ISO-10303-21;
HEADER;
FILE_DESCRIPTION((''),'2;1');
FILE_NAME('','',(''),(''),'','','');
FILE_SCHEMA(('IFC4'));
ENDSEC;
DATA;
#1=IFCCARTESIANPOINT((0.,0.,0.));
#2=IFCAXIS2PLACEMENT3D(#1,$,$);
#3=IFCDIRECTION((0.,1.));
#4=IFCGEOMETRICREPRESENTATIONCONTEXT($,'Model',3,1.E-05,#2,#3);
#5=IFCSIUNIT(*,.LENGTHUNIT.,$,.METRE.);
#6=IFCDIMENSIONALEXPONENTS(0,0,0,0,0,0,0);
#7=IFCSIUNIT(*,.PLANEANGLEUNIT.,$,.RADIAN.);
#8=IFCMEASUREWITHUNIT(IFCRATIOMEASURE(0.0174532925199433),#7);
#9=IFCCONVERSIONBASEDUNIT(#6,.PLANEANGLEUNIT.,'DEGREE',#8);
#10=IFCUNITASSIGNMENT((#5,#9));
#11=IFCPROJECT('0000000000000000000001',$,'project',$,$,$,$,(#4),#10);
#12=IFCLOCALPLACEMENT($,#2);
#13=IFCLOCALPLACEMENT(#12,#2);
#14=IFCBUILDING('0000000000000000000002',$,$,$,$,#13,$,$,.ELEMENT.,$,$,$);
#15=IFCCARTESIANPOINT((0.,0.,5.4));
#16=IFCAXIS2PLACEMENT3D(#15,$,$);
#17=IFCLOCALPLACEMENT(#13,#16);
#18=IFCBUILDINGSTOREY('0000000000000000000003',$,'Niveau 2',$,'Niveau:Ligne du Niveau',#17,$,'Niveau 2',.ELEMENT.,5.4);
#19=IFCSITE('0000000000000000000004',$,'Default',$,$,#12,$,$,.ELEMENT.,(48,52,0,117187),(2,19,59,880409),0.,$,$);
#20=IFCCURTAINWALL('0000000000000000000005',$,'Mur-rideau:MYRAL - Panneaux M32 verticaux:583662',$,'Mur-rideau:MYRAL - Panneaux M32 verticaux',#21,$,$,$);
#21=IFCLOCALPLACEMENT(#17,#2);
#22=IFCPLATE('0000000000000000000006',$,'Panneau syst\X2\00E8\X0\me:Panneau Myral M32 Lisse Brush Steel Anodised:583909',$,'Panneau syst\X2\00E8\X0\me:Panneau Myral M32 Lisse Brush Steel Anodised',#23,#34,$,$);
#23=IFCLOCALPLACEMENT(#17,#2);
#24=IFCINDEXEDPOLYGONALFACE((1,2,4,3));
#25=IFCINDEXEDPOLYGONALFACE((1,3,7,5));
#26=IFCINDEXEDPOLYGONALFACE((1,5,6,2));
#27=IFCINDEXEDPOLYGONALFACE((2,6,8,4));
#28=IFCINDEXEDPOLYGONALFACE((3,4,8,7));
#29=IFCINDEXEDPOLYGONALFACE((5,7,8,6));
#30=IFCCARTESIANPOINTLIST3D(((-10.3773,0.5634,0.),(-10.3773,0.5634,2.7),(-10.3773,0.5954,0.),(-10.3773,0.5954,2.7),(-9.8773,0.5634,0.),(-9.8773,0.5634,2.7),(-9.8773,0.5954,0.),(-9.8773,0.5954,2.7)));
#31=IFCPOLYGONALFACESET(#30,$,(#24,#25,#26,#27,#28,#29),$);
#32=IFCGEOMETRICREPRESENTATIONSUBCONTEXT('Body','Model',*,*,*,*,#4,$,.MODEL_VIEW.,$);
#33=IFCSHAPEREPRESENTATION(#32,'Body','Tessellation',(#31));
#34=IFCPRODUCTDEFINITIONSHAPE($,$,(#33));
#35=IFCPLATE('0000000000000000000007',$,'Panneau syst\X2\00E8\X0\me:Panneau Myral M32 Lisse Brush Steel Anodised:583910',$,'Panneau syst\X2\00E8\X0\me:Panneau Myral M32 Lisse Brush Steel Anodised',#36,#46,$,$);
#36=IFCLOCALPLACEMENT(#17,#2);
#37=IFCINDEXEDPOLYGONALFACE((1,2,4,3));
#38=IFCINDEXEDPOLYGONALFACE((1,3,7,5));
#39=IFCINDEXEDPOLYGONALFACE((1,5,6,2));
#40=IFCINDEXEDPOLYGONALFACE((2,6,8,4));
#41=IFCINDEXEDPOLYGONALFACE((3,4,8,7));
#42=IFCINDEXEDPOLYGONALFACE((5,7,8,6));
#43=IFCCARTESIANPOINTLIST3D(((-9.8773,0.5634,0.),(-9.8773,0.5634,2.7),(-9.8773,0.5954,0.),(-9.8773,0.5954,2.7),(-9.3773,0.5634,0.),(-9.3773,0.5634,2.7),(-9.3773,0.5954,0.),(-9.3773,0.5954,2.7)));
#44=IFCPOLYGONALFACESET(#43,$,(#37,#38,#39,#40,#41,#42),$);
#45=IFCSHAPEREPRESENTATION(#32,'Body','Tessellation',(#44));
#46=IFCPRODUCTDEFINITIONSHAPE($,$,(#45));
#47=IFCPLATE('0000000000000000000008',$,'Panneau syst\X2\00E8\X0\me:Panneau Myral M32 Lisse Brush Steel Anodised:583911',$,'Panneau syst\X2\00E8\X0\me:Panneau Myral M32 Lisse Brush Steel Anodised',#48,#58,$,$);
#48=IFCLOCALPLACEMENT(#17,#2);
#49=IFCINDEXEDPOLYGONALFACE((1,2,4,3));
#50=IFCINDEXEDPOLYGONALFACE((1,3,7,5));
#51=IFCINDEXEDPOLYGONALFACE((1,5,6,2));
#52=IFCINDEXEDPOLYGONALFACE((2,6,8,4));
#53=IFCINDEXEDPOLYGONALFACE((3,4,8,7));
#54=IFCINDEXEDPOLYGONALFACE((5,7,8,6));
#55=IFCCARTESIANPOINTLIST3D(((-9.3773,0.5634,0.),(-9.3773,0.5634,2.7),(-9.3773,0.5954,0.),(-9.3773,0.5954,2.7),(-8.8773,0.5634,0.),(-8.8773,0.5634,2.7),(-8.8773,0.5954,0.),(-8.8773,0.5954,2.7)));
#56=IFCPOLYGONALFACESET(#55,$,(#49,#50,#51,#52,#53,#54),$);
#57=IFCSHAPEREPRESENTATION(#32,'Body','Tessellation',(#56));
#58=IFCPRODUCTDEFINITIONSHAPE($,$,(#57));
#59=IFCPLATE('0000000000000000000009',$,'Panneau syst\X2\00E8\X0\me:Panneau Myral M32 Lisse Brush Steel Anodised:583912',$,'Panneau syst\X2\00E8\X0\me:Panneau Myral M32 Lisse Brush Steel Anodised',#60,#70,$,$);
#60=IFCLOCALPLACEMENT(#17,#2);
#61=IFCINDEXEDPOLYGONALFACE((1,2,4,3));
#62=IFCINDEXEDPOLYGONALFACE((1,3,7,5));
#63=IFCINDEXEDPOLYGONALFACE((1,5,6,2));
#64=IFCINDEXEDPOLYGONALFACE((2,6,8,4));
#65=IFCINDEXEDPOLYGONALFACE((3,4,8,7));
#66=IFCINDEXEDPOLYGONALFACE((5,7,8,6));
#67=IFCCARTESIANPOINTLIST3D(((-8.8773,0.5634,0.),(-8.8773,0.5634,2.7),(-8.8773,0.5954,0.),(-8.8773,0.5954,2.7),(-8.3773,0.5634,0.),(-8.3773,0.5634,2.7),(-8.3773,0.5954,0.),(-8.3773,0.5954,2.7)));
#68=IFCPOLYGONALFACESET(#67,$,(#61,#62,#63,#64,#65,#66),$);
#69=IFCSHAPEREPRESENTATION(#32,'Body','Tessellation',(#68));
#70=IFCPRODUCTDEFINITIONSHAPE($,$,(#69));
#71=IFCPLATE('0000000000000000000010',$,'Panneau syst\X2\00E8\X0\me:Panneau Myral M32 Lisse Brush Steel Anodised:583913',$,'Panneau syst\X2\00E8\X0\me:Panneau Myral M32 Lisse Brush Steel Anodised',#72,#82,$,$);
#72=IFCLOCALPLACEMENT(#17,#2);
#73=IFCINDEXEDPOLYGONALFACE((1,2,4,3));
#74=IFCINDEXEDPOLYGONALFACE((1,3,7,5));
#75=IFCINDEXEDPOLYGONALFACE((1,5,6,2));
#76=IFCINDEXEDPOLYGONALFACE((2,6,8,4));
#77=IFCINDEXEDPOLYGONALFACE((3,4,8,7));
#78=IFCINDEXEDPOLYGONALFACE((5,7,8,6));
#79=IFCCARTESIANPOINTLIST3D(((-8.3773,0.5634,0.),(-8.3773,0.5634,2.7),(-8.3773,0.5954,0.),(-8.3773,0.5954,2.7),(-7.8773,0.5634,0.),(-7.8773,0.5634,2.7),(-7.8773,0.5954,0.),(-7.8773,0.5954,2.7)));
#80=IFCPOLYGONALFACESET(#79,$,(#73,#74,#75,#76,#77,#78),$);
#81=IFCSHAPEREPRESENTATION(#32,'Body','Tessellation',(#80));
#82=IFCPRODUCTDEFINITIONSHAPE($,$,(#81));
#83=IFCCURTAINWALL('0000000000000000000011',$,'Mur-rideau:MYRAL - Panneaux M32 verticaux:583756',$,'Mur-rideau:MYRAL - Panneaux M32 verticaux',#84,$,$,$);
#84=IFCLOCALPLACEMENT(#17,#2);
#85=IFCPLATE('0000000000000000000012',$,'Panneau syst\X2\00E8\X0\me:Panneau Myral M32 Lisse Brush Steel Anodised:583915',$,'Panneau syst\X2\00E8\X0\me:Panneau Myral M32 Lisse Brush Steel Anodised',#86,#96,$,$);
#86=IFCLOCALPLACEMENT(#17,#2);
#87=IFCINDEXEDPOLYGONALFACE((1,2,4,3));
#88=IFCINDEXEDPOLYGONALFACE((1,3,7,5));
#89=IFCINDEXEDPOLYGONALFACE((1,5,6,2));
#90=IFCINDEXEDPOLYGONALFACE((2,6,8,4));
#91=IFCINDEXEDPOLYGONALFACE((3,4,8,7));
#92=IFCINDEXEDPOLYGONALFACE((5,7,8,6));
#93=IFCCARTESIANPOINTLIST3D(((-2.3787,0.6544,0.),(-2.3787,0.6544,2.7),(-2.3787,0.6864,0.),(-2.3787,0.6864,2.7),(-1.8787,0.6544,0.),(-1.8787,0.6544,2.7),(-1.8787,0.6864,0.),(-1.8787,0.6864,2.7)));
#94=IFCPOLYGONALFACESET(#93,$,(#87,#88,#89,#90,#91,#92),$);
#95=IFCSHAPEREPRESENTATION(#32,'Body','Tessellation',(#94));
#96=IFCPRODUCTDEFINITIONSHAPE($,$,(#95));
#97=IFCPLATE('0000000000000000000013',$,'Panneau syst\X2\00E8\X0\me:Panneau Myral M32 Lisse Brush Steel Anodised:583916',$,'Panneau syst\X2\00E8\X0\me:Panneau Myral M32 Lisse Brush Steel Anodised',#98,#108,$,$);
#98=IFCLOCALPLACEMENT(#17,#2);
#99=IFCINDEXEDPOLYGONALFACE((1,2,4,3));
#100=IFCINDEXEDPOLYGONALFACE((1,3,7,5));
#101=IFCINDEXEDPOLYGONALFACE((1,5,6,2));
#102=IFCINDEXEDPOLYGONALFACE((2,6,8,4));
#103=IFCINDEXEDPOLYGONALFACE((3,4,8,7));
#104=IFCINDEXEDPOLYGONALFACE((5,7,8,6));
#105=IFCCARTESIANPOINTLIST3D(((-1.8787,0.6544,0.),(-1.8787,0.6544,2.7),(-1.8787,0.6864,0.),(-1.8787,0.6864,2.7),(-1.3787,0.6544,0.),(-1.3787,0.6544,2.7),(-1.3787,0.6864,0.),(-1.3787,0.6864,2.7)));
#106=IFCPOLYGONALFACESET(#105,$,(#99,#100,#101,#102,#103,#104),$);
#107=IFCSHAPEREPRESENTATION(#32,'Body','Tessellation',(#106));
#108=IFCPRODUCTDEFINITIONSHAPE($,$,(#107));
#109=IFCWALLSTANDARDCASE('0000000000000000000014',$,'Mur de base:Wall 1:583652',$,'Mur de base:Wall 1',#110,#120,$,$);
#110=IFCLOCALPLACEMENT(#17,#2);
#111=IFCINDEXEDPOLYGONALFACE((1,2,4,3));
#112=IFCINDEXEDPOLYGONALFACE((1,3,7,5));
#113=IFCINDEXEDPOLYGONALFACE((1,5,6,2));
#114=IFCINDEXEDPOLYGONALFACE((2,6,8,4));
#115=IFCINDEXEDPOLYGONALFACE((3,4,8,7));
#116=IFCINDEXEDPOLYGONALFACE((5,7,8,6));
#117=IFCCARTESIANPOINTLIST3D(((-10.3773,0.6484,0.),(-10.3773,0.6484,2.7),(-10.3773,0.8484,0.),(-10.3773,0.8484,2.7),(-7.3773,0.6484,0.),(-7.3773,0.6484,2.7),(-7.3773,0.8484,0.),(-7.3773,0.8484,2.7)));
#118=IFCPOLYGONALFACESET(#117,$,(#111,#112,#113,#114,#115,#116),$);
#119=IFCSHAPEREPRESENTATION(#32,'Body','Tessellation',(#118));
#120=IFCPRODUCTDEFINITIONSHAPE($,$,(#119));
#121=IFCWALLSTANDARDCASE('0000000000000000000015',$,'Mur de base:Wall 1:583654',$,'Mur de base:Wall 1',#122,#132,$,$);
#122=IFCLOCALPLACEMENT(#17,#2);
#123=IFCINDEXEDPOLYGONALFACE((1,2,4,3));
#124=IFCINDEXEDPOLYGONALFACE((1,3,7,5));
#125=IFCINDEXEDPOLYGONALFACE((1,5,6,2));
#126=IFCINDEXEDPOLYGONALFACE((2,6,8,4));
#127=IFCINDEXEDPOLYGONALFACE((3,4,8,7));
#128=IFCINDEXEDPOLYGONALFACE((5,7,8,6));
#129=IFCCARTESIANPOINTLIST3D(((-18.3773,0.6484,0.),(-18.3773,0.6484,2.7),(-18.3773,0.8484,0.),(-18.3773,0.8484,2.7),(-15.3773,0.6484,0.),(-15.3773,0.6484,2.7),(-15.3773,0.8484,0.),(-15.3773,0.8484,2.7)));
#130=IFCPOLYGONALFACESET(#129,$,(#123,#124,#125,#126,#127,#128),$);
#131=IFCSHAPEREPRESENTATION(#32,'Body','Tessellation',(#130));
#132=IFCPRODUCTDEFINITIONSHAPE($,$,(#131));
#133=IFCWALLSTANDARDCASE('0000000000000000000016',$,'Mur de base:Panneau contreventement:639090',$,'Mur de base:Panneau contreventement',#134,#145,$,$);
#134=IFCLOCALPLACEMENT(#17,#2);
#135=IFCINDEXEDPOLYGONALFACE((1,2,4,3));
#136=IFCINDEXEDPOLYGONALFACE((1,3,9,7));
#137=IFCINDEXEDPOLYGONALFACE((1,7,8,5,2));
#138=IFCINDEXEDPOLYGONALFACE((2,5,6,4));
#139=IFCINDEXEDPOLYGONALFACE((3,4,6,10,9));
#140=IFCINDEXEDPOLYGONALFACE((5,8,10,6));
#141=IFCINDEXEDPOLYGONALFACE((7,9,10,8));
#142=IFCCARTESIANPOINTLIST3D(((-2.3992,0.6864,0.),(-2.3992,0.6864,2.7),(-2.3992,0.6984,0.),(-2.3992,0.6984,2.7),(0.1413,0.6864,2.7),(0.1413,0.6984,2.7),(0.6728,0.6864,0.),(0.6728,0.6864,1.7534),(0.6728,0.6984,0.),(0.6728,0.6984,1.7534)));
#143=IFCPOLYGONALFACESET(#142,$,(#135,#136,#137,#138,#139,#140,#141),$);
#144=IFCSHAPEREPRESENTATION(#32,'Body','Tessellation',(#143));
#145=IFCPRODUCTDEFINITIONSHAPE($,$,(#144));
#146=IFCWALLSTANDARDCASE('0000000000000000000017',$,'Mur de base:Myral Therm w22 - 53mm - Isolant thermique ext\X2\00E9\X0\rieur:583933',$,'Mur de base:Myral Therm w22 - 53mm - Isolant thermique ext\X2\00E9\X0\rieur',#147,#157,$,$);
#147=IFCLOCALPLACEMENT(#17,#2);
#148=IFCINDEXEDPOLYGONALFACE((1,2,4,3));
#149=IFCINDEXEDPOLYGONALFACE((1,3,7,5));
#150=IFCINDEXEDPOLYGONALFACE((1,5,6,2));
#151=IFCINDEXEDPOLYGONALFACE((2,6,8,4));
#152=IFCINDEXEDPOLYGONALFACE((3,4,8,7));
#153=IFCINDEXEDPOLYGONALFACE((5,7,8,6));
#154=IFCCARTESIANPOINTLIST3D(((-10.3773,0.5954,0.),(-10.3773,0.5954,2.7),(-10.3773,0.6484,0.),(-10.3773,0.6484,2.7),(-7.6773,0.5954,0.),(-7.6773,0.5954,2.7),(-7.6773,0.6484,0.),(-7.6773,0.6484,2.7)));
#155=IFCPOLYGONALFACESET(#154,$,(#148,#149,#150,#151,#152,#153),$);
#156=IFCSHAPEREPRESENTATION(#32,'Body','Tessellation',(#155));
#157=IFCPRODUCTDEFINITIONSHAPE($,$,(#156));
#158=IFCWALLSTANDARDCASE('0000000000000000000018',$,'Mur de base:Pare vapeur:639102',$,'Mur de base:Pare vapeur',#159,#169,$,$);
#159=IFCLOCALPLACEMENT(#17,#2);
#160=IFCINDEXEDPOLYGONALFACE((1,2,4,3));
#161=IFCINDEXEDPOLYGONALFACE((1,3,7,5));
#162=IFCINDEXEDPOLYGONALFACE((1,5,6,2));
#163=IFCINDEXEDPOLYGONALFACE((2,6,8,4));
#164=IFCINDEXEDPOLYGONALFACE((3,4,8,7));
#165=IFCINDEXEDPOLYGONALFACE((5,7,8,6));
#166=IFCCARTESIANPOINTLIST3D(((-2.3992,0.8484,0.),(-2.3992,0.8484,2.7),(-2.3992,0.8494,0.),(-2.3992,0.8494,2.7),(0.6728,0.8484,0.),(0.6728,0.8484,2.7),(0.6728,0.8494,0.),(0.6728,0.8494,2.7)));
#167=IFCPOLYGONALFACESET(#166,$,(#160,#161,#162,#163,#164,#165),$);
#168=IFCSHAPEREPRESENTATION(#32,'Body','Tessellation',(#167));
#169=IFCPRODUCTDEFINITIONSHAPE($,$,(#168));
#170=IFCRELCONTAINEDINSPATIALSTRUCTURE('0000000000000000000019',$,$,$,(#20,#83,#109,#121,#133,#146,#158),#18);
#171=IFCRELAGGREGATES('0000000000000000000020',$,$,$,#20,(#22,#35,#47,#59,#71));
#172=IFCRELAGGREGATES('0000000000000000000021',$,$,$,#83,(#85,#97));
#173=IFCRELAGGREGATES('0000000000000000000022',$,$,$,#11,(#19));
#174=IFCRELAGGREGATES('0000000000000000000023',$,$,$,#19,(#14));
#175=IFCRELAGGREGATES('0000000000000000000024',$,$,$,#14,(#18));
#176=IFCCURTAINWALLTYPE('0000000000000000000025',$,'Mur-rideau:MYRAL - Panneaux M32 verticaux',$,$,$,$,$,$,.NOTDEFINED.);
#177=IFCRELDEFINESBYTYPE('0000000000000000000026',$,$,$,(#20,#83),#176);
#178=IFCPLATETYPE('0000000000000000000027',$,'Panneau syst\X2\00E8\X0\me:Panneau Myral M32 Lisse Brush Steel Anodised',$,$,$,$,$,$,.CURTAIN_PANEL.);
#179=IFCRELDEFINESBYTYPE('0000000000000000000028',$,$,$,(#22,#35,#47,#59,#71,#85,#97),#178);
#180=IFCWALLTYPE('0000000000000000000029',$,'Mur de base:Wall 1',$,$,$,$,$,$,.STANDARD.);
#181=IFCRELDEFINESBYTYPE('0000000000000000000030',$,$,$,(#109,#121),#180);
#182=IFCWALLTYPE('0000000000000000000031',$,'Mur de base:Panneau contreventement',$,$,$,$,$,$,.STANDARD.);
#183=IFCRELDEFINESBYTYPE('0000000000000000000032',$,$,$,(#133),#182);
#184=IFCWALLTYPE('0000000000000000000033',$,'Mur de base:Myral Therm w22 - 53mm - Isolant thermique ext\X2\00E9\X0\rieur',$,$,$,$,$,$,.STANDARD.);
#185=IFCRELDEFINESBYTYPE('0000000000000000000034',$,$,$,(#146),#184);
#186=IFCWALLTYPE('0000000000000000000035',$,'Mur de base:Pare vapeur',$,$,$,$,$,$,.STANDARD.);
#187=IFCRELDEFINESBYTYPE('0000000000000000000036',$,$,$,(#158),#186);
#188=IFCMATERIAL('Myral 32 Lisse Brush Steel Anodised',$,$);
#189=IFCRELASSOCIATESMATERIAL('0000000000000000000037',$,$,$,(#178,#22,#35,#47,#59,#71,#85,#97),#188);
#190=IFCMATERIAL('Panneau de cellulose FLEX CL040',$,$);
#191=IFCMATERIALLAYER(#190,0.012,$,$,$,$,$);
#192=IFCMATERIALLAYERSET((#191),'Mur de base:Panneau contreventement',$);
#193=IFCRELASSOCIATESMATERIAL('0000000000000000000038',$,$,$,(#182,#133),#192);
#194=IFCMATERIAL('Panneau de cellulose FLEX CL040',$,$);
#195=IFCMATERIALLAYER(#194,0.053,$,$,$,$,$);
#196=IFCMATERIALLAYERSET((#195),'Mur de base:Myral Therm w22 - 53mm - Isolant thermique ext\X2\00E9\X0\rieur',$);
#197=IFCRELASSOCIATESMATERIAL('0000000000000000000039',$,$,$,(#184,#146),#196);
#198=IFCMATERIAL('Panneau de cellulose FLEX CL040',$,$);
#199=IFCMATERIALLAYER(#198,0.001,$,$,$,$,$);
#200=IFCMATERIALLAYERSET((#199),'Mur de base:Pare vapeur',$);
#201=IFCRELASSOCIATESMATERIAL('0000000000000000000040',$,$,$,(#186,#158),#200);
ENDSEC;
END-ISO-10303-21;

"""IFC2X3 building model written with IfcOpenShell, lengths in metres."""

from ifc_helpers import new_model, entity, si_unit, converted_unit, direction, frame, frame_2d, origin, origin_2d_with_axis, place, context, subcontext, project, spatial, rectangle, extrude, clip, halfspace, source, transform, mapped, material, layer, layer_set, layer_usage, type_object, type_shapes, element, aggregate, save


model = new_model("IFC2X3")

# Units and contexts
model_context = context("Model", 3, precision=1e-05, world=origin(), true_north=direction((0.0, 1.0)))
body_context = subcontext(model_context, "Body", "Model", "MODEL_VIEW")
ifc_project = project(units=[si_unit("LENGTHUNIT", "METRE"), converted_unit("PLANEANGLEUNIT", "DEGREE", entity("IfcRatioMeasure", 0.0174532925199433), si_unit("PLANEANGLEUNIT", "RADIAN"), dimensions=[0, 0, 0, 0, 0, 0, 0])], contexts=[model_context])

# Site, building, storey
site_placement = place(None, origin())
site = spatial("IfcSite", under=ifc_project, at=site_placement, Name="Default", CompositionType="ELEMENT", RefLatitude=(48, 52, 0, 117187), RefLongitude=(2, 19, 59, 880409), RefElevation=0.0)
building_placement = place(site_placement, origin())
building = spatial("IfcBuilding", under=site, at=building_placement, CompositionType="ELEMENT")
storey_placement = place(building_placement, frame((0.0, 0.0, 5.4)))
storey = spatial("IfcBuildingStorey", under=building, at=storey_placement, Name="Niveau 2", ObjectType="Niveau:Ligne du Niveau", LongName="Niveau 2", CompositionType="ELEMENT", Elevation=5.4)

# Shared definitions
ifc_material_1 = material(Name="Panneau de cellulose FLEX CL040")

# Curtain walls, plates
curtain_wall_type_1 = type_object("IfcCurtainWallType", Name="Mur-rideau:MYRAL - Panneaux M32 verticaux", PredefinedType="NOTDEFINED")
ifc_material_2 = material(Name="Myral 32 Lisse Brush Steel Anodised")
plate_type = type_object("IfcPlateType", Name="Panneau système:Panneau Myral M32 Lisse Brush Steel Anodised", PredefinedType="CURTAIN_PANEL", material=ifc_material_2)
shared_shape_1 = source(origin(), body_context, "Body", "SweptSolid", [
    extrude(rectangle(XDim=0.032, YDim=0.5, at=origin_2d_with_axis()), frame((0.0, -0.016, 0.0), z_axis=(0.0, 0.0, 1.0), x_axis=(0.0, 1.0, 0.0)), (0.0, 0.0, 1.0), 2.7),
])
type_shapes(plate_type, [shared_shape_1])
curtain_wall_1_placement = place(storey_placement, frame((0.0, 0.0, -5.4)))
curtain_wall_1 = element("IfcCurtainWall", 1, at=curtain_wall_1_placement, inside=storey, type_object=curtain_wall_type_1, Name="Mur-rideau:MYRAL - Panneaux M32 verticaux:583662", ObjectType="Mur-rideau:MYRAL - Panneaux M32 verticaux")
plate_1_placement = place(curtain_wall_1_placement, frame((-10.1273, 0.5954, 5.4)))
plate_1 = element("IfcPlate", 2, at=plate_1_placement, type_object=plate_type, material=ifc_material_2, Name="Panneau système:Panneau Myral M32 Lisse Brush Steel Anodised:583909", ObjectType="Panneau système:Panneau Myral M32 Lisse Brush Steel Anodised", context=body_context, shape_type="MappedRepresentation", body=[
    mapped(shared_shape_1, transform((0.0, 0.0, 0.0), scale=1.0)),
])
plate_2_placement = place(curtain_wall_1_placement, frame((-9.6273, 0.5954, 5.4)))
plate_2 = element("IfcPlate", 3, at=plate_2_placement, type_object=plate_type, material=ifc_material_2, Name="Panneau système:Panneau Myral M32 Lisse Brush Steel Anodised:583910", ObjectType="Panneau système:Panneau Myral M32 Lisse Brush Steel Anodised", context=body_context, shape_type="MappedRepresentation", body=[
    mapped(shared_shape_1, transform((0.0, 0.0, 0.0), scale=1.0)),
])
plate_3_placement = place(curtain_wall_1_placement, frame((-9.1273, 0.5954, 5.4)))
plate_3 = element("IfcPlate", 4, at=plate_3_placement, type_object=plate_type, material=ifc_material_2, Name="Panneau système:Panneau Myral M32 Lisse Brush Steel Anodised:583911", ObjectType="Panneau système:Panneau Myral M32 Lisse Brush Steel Anodised", context=body_context, shape_type="MappedRepresentation", body=[
    mapped(shared_shape_1, transform((0.0, 0.0, 0.0), scale=1.0)),
])
plate_4_placement = place(curtain_wall_1_placement, frame((-8.6273, 0.5954, 5.4)))
plate_4 = element("IfcPlate", 5, at=plate_4_placement, type_object=plate_type, material=ifc_material_2, Name="Panneau système:Panneau Myral M32 Lisse Brush Steel Anodised:583912", ObjectType="Panneau système:Panneau Myral M32 Lisse Brush Steel Anodised", context=body_context, shape_type="MappedRepresentation", body=[
    mapped(shared_shape_1, transform((0.0, 0.0, 0.0), scale=1.0)),
])
plate_5_placement = place(curtain_wall_1_placement, frame((-8.1273, 0.5954, 5.4)))
plate_5 = element("IfcPlate", 6, at=plate_5_placement, type_object=plate_type, material=ifc_material_2, Name="Panneau système:Panneau Myral M32 Lisse Brush Steel Anodised:583913", ObjectType="Panneau système:Panneau Myral M32 Lisse Brush Steel Anodised", context=body_context, shape_type="MappedRepresentation", body=[
    mapped(shared_shape_1, transform((0.0, 0.0, 0.0), scale=1.0)),
])
aggregate(curtain_wall_1, [plate_1, plate_2, plate_3, plate_4, plate_5])
curtain_wall_2_placement = place(storey_placement, frame((0.0, 0.0, -5.4)))
curtain_wall_2 = element("IfcCurtainWall", 7, at=curtain_wall_2_placement, inside=storey, type_object=curtain_wall_type_1, Name="Mur-rideau:MYRAL - Panneaux M32 verticaux:583756", ObjectType="Mur-rideau:MYRAL - Panneaux M32 verticaux")
plate_6_placement = place(curtain_wall_2_placement, frame((-2.1287, 0.6864, 5.4)))
plate_6 = element("IfcPlate", 8, at=plate_6_placement, type_object=plate_type, material=ifc_material_2, Name="Panneau système:Panneau Myral M32 Lisse Brush Steel Anodised:583915", ObjectType="Panneau système:Panneau Myral M32 Lisse Brush Steel Anodised", context=body_context, shape_type="MappedRepresentation", body=[
    mapped(shared_shape_1, transform((0.0, 0.0, 0.0), scale=1.0)),
])
plate_7_placement = place(curtain_wall_2_placement, frame((-1.6287, 0.6864, 5.4)))
plate_7 = element("IfcPlate", 9, at=plate_7_placement, type_object=plate_type, material=ifc_material_2, Name="Panneau système:Panneau Myral M32 Lisse Brush Steel Anodised:583916", ObjectType="Panneau système:Panneau Myral M32 Lisse Brush Steel Anodised", context=body_context, shape_type="MappedRepresentation", body=[
    mapped(shared_shape_1, transform((0.0, 0.0, 0.0), scale=1.0)),
])
aggregate(curtain_wall_2, [plate_6, plate_7])

# Walls
wall_type_1 = type_object("IfcWallType", Name="Mur de base:Wall 1", PredefinedType="STANDARD")
for number, where, name in (
    (10, (-10.3773, 0.7484, 0.0), "Mur de base:Wall 1:583652"),
    (11, (-18.3773, 0.7484, 0.0), "Mur de base:Wall 1:583654"),
):
    element("IfcWallStandardCase", number, at=place(storey_placement, frame(where)), inside=storey, type_object=wall_type_1, Name=name, ObjectType="Mur de base:Wall 1", context=body_context, shape_type="SweptSolid", body=[
        extrude(rectangle(XDim=3.0, YDim=0.2, at=frame_2d((1.5, 0.0), x_axis=(-1.0, 0.0))), origin(), (0.0, 0.0, 1.0), 2.7),
    ])
ifc_layer_1 = layer(ifc_material_1, 0.012)
ifc_layer_set_1 = layer_set([ifc_layer_1], Name="Mur de base:Panneau contreventement")
ifc_layer_usage_1 = layer_usage(ifc_layer_set_1, "AXIS2", "NEGATIVE", 0.006)
wall_type_2 = type_object("IfcWallType", Name="Mur de base:Panneau contreventement", PredefinedType="STANDARD", material=ifc_layer_set_1)
wall_1_placement = place(storey_placement, frame((-2.3992, 0.6924, 0.0)))
element("IfcWallStandardCase", 12, at=wall_1_placement, inside=storey, type_object=wall_type_2, material=ifc_layer_usage_1, Name="Mur de base:Panneau contreventement:639090", ObjectType="Mur de base:Panneau contreventement", context=body_context, shape_type="Clipping", body=[
    clip(extrude(rectangle(XDim=3.072, YDim=0.012, at=frame_2d((1.536, 0.0), x_axis=(-1.0, 0.0))), origin(), (0.0, 0.0, 1.0), 2.7), halfspace(frame((2.5405, -0.006, 2.7), z_axis=(0.871952, 0.0, 0.489592), x_axis=(0.0, 1.0, 0.0)), False)),
])
ifc_material_3 = material(Name="Panneau de cellulose FLEX CL040")
ifc_layer_2 = layer(ifc_material_3, 0.053)
ifc_layer_set_2 = layer_set([ifc_layer_2], Name="Mur de base:Myral Therm w22 - 53mm - Isolant thermique extérieur")
ifc_layer_usage_2 = layer_usage(ifc_layer_set_2, "AXIS2", "NEGATIVE", 0.0265)
wall_type_3 = type_object("IfcWallType", Name="Mur de base:Myral Therm w22 - 53mm - Isolant thermique extérieur", PredefinedType="STANDARD", material=ifc_layer_set_2)
wall_2_placement = place(storey_placement, frame((-10.3773, 0.6219, 0.0)))
element("IfcWallStandardCase", 13, at=wall_2_placement, inside=storey, type_object=wall_type_3, material=ifc_layer_usage_2, Name="Mur de base:Myral Therm w22 - 53mm - Isolant thermique extérieur:583933", ObjectType="Mur de base:Myral Therm w22 - 53mm - Isolant thermique extérieur", context=body_context, shape_type="SweptSolid", body=[
    extrude(rectangle(XDim=2.7, YDim=0.053, at=frame_2d((1.35, 0.0), x_axis=(-1.0, 0.0))), origin(), (0.0, 0.0, 1.0), 2.7),
])
ifc_material_4 = material(Name="Panneau de cellulose FLEX CL040")
ifc_layer_3 = layer(ifc_material_4, 0.001)
ifc_layer_set_3 = layer_set([ifc_layer_3], Name="Mur de base:Pare vapeur")
ifc_layer_usage_3 = layer_usage(ifc_layer_set_3, "AXIS2", "NEGATIVE", 0.0005)
wall_type_4 = type_object("IfcWallType", Name="Mur de base:Pare vapeur", PredefinedType="STANDARD", material=ifc_layer_set_3)
wall_3_placement = place(storey_placement, frame((-2.3992, 0.8489, 0.0)))
element("IfcWallStandardCase", 14, at=wall_3_placement, inside=storey, type_object=wall_type_4, material=ifc_layer_usage_3, Name="Mur de base:Pare vapeur:639102", ObjectType="Mur de base:Pare vapeur", context=body_context, shape_type="SweptSolid", body=[
    extrude(rectangle(XDim=3.072, YDim=0.001, at=frame_2d((1.536, 0.0), x_axis=(-1.0, 0.0))), origin(), (0.0, 0.0, 1.0), 2.7),
])

save(model, "model.ifc")
